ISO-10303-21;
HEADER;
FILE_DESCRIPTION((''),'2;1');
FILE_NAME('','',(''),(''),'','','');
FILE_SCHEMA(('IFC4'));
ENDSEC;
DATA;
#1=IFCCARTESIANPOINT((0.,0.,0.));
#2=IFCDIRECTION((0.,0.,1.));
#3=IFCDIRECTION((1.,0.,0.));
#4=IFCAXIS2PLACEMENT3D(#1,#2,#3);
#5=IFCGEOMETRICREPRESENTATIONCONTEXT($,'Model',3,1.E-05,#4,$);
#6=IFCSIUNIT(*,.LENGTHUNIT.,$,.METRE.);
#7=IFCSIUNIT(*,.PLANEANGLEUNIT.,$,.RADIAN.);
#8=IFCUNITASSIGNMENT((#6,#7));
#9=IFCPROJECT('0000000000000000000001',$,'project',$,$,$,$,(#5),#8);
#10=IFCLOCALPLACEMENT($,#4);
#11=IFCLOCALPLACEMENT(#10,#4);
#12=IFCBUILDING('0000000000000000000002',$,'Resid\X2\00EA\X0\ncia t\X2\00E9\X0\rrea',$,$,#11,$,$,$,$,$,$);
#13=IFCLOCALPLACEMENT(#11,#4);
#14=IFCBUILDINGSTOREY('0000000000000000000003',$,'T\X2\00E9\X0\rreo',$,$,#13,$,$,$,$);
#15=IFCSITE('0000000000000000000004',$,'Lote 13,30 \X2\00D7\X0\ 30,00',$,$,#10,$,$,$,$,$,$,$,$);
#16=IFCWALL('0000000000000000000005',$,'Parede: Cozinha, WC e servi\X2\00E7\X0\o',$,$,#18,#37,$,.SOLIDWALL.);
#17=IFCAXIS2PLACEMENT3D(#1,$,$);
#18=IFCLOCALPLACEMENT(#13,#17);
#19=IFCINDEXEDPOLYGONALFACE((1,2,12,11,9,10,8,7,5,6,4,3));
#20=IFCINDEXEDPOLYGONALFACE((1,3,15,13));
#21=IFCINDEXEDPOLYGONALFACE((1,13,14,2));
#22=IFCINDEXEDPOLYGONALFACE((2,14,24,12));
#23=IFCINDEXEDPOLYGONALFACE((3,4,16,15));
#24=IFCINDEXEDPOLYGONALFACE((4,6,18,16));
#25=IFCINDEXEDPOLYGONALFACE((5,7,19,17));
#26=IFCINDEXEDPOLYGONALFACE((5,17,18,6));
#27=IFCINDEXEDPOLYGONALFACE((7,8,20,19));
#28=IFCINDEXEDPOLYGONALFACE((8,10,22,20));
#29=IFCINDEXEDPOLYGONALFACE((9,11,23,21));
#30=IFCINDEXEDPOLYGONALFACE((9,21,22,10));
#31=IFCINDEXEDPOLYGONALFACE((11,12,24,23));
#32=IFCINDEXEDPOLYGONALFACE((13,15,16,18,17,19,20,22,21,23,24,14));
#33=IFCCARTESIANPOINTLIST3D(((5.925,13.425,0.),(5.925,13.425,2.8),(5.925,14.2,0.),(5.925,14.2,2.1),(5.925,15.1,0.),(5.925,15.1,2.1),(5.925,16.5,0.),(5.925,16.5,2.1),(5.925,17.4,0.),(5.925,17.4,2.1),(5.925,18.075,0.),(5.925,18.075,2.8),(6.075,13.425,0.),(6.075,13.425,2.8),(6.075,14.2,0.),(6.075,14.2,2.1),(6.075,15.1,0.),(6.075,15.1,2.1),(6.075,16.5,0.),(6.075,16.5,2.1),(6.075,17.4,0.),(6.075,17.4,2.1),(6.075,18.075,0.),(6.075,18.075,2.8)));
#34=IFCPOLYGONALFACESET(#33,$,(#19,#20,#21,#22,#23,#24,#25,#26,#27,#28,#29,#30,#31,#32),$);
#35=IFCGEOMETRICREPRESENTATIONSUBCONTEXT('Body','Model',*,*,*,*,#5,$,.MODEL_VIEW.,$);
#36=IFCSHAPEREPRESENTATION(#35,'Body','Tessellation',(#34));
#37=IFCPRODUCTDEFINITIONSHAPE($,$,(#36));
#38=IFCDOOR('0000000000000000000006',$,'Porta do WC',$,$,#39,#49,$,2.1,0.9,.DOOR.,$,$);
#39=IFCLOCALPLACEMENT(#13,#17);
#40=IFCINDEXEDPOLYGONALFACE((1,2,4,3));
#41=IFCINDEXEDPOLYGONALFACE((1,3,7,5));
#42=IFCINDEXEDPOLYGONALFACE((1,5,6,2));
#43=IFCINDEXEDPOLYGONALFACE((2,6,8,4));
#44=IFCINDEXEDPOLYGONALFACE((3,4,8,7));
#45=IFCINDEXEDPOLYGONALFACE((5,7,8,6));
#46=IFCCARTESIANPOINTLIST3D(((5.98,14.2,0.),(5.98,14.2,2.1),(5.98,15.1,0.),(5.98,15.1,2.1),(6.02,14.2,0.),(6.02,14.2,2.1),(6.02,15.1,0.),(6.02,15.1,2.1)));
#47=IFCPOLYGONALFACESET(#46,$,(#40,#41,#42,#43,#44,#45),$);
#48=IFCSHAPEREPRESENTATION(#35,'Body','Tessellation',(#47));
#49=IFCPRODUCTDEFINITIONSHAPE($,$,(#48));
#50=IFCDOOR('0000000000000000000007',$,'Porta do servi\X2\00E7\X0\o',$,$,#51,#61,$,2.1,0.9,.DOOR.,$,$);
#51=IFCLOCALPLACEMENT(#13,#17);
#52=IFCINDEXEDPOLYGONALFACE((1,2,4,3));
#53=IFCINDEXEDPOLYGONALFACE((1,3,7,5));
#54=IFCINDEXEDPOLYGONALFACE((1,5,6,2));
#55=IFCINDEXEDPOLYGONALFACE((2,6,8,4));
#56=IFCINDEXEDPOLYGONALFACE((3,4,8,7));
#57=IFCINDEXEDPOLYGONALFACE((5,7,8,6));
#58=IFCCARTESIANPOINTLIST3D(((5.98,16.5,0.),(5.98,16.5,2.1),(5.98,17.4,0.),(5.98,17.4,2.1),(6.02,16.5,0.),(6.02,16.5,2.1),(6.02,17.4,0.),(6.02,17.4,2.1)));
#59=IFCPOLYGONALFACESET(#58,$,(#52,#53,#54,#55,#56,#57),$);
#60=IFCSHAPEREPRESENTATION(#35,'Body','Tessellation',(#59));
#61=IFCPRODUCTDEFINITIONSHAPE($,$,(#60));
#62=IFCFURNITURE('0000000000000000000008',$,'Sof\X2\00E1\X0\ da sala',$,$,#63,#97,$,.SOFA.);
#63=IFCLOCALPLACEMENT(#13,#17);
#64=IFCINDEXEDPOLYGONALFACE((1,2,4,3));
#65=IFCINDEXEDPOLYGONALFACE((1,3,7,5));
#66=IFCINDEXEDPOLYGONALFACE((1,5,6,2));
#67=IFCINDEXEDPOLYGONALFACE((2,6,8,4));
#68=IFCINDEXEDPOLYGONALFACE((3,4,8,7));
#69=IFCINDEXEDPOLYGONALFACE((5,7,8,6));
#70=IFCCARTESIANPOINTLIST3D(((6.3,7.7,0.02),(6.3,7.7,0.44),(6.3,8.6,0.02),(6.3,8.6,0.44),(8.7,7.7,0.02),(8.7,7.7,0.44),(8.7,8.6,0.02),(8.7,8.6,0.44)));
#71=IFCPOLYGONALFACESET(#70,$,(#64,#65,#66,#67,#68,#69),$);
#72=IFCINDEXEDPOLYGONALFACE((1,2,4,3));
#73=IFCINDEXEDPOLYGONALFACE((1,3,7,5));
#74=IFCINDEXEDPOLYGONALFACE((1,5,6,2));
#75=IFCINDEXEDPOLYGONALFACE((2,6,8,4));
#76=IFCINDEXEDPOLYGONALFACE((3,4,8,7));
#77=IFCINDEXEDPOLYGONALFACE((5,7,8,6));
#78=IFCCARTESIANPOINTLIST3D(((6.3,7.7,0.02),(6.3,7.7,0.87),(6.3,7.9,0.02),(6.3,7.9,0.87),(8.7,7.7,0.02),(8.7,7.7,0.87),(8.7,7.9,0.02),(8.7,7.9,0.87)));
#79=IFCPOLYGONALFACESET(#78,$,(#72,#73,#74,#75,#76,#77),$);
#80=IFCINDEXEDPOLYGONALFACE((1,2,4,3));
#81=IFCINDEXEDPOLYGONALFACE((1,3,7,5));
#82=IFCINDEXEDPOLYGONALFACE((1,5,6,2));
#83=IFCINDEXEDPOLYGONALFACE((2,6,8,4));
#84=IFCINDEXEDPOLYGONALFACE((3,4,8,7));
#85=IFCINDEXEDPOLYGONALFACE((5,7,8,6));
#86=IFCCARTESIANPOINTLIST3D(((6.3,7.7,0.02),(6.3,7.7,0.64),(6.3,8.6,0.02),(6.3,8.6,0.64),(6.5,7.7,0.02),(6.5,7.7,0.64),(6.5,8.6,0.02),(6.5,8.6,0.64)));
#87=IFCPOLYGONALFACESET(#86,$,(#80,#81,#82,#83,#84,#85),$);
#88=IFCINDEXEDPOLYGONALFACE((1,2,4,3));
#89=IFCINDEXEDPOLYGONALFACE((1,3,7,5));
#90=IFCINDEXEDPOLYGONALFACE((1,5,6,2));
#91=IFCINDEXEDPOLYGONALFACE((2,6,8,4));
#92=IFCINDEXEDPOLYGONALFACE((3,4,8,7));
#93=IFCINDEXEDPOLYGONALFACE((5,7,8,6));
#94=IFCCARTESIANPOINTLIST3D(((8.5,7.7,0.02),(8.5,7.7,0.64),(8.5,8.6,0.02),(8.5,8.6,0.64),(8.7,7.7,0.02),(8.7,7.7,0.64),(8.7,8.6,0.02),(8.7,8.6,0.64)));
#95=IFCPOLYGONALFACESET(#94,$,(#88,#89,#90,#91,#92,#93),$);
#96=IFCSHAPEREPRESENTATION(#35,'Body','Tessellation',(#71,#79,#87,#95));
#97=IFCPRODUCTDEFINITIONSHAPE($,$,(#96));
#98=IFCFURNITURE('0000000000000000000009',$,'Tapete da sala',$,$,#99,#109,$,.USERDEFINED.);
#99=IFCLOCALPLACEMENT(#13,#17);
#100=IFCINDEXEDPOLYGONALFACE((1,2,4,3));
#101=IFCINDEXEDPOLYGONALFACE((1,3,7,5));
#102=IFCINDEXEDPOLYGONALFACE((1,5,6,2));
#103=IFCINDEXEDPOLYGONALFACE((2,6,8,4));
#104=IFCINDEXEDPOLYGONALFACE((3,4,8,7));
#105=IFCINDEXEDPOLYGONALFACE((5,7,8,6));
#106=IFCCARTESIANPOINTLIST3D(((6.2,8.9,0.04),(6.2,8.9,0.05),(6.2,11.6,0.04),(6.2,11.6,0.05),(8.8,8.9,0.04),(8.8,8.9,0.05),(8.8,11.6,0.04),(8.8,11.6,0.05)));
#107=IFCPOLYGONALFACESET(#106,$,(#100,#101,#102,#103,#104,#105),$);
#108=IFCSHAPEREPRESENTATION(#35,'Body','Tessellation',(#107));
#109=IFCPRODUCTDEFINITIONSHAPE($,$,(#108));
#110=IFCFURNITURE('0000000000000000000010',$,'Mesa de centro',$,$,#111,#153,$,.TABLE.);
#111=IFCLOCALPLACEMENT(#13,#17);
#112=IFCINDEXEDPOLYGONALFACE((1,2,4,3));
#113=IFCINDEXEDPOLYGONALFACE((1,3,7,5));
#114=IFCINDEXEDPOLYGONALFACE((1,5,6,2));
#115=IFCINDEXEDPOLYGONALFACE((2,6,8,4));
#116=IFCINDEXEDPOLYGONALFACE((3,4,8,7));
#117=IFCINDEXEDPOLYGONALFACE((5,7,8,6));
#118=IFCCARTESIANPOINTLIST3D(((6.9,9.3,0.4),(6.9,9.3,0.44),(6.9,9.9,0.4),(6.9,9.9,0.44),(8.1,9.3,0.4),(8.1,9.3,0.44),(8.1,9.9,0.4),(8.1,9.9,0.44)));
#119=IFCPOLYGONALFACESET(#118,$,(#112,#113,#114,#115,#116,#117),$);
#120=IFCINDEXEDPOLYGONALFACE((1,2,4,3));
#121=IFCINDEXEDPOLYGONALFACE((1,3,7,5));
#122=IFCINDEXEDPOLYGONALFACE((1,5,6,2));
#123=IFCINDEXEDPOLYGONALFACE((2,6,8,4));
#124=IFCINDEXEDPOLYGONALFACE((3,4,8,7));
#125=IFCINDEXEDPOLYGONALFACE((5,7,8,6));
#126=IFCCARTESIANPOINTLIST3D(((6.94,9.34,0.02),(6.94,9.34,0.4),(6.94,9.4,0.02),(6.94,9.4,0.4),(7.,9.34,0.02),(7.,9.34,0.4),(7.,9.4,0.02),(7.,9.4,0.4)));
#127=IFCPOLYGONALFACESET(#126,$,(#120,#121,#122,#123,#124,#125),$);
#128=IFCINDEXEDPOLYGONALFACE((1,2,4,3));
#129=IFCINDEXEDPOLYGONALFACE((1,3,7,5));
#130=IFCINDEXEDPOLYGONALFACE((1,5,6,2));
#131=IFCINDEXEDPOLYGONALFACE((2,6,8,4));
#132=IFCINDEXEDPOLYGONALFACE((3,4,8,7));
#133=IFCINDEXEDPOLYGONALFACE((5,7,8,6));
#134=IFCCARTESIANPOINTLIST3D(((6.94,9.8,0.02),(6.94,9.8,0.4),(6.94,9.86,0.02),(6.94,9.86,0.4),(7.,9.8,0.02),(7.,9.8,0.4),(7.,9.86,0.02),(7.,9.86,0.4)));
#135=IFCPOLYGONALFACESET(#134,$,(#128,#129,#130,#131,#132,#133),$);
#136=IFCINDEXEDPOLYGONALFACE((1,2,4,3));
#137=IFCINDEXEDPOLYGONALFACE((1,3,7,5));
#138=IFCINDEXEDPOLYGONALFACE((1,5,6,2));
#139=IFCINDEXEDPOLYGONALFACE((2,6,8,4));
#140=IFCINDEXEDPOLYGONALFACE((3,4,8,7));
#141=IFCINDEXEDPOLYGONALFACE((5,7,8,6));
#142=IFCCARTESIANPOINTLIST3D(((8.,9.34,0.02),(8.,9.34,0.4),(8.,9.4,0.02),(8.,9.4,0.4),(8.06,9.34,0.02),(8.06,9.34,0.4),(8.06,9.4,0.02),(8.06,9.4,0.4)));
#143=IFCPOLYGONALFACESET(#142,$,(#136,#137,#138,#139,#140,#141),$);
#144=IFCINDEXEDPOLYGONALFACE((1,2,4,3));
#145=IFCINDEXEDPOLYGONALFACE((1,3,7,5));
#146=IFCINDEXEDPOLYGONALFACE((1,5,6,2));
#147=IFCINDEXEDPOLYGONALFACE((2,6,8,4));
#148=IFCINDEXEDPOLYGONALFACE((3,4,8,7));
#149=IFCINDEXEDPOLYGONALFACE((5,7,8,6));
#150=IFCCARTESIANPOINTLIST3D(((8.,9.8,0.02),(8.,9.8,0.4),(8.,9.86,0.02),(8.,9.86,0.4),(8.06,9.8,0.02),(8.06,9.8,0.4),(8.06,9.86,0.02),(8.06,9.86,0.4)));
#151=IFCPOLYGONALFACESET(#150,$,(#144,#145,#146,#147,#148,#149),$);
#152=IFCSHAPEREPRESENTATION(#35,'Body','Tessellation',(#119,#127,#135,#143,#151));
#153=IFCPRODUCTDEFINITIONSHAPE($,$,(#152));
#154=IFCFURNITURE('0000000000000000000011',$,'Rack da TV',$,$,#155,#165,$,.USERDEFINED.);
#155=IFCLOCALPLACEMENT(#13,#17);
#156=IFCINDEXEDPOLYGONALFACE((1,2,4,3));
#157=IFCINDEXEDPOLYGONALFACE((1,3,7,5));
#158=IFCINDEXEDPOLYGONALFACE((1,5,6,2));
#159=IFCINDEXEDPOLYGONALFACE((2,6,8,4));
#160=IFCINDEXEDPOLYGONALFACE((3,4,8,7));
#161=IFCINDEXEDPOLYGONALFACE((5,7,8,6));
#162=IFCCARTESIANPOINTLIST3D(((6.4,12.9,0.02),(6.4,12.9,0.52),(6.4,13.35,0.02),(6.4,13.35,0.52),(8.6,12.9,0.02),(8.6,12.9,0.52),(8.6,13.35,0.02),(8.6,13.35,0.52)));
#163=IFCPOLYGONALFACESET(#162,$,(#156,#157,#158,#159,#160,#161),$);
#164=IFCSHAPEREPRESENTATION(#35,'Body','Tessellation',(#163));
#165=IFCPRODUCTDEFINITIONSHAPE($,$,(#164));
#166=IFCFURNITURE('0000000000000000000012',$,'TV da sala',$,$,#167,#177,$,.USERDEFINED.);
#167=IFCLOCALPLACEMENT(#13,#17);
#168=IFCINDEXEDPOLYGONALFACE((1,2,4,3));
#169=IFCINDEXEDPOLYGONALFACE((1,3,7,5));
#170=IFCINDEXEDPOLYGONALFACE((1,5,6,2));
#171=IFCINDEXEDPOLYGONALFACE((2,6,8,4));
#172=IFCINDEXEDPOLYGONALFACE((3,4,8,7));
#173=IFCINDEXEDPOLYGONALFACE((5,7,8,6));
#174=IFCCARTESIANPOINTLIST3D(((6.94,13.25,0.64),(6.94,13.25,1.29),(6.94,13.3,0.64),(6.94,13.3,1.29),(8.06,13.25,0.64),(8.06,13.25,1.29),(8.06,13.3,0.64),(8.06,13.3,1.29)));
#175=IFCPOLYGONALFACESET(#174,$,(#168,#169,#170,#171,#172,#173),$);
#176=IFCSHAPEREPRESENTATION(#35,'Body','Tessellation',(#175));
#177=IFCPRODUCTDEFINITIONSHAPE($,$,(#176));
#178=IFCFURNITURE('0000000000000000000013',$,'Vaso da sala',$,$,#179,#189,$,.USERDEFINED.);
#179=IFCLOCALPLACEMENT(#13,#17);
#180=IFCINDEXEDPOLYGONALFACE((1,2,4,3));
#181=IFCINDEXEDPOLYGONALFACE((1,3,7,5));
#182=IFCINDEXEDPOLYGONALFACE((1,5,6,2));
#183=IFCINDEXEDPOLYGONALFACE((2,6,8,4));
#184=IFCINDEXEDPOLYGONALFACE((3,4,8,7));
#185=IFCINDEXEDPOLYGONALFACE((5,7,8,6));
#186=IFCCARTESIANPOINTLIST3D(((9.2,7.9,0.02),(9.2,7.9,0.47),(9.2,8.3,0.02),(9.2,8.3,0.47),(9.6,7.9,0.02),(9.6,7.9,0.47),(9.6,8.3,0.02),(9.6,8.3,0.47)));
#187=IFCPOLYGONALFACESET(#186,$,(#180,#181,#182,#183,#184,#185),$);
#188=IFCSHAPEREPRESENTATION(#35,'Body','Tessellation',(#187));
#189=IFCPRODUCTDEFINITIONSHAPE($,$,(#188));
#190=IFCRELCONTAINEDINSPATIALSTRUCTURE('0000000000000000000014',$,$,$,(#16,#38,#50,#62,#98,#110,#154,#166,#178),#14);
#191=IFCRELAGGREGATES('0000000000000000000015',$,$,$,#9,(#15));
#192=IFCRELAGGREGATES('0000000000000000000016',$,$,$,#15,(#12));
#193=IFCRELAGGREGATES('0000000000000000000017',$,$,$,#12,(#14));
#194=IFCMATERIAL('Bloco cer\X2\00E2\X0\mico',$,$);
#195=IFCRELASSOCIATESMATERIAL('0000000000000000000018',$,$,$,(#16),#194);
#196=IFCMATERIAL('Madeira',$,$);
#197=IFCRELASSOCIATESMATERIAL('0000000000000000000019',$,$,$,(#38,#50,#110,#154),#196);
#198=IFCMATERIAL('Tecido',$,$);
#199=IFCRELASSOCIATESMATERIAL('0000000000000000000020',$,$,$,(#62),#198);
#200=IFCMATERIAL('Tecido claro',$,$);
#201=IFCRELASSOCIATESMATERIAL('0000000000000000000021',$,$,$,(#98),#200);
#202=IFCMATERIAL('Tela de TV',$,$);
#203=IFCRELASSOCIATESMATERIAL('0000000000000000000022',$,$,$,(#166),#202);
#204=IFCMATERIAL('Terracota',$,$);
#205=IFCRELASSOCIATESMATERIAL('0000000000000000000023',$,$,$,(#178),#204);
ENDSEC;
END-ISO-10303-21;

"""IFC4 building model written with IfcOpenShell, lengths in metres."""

from ifc_helpers import new_model, si_unit, frame, origin_with_axes, place, context, subcontext, project, spatial, line, indexed_curve, outline, extrude, material, element, fill, save


model = new_model("IFC4")

# Units and contexts
model_context = context("Model", 3, precision=1e-05, world=origin_with_axes())
body_context = subcontext(model_context, "Body", "Model", "MODEL_VIEW")
ifc_project = project(units=[si_unit("LENGTHUNIT", "METRE"), si_unit("PLANEANGLEUNIT", "RADIAN")], contexts=[model_context])

# Site, building, storey
site_placement = place(None, origin_with_axes())
site = spatial("IfcSite", under=ifc_project, at=site_placement, Name="Lote 13,30 × 30,00")
building_placement = place(site_placement, origin_with_axes())
building = spatial("IfcBuilding", under=site, at=building_placement, Name="Residência térrea")
storey_placement = place(building_placement, origin_with_axes())
storey = spatial("IfcBuildingStorey", under=building, at=storey_placement, Name="Térreo")

# Shared definitions
ifc_material_1 = material(Name="Concreto armado")

# Shared definitions
ifc_material_2 = material(Name="Bloco cerâmico")

# Wall, openings, doors
wall_1_placement = place(storey_placement, frame((5.925, 13.425, 0.0), z_axis=(0.0, 0.0, 1.0), x_axis=(1.0, 0.0, 0.0)))
wall_1 = element("IfcWall", 1, at=wall_1_placement, inside=storey, material=ifc_material_2, Name="Parede: Cozinha, WC e serviço", PredefinedType="SOLIDWALL", context=body_context, shape_type="SweptSolid", body=[
    extrude(outline(indexed_curve([(0.0, 0.0), (0.15, 0.0), (0.15, 4.65), (0.0, 4.65)], segments=[line(1, 2, 3, 4, 1)])), origin_with_axes(), (0.0, 0.0, 1.0), 2.8),
])
opening_1_placement = place(wall_1_placement, frame((-0.05, 0.775, 0.0), z_axis=(0.0, 0.0, 1.0), x_axis=(1.0, 0.0, 0.0)))
opening_1 = element("IfcOpeningElement", 2, at=opening_1_placement, cuts=wall_1, material=ifc_material_1, PredefinedType="OPENING", context=body_context, shape_type="SweptSolid", body=[
    extrude(outline(indexed_curve([(0.0, 0.0), (0.25, 0.0), (0.25, 0.9), (0.0, 0.9)], segments=[line(1, 2, 3, 4, 1)])), origin_with_axes(), (0.0, 0.0, 1.0), 2.1),
])
opening_2_placement = place(wall_1_placement, frame((-0.05, 3.075, 0.0), z_axis=(0.0, 0.0, 1.0), x_axis=(1.0, 0.0, 0.0)))
opening_2 = element("IfcOpeningElement", 3, at=opening_2_placement, cuts=wall_1, material=ifc_material_1, PredefinedType="OPENING", context=body_context, shape_type="SweptSolid", body=[
    extrude(outline(indexed_curve([(0.0, 0.0), (0.25, 0.0), (0.25, 0.9), (0.0, 0.9)], segments=[line(1, 2, 3, 4, 1)])), origin_with_axes(), (0.0, 0.0, 1.0), 2.1),
])
ifc_material_3 = material(Name="Madeira")
door_1_placement = place(storey_placement, frame((5.98, 14.2, 0.0), z_axis=(0.0, 0.0, 1.0), x_axis=(1.0, 0.0, 0.0)))
door_1 = element("IfcDoor", 4, at=door_1_placement, inside=storey, material=ifc_material_3, Name="Porta do WC", OverallHeight=2.1, OverallWidth=0.9, PredefinedType="DOOR", context=body_context, shape_type="SweptSolid", body=[
    extrude(outline(indexed_curve([(0.0, 0.0), (0.04, 0.0), (0.04, 0.9), (0.0, 0.9)], segments=[line(1, 2, 3, 4, 1)])), origin_with_axes(), (0.0, 0.0, 1.0), 2.1),
])
fill(opening_1, door_1)
door_2_placement = place(storey_placement, frame((5.98, 16.5, 0.0), z_axis=(0.0, 0.0, 1.0), x_axis=(1.0, 0.0, 0.0)))
door_2 = element("IfcDoor", 5, at=door_2_placement, inside=storey, material=ifc_material_3, Name="Porta do serviço", OverallHeight=2.1, OverallWidth=0.9, PredefinedType="DOOR", context=body_context, shape_type="SweptSolid", body=[
    extrude(outline(indexed_curve([(0.0, 0.0), (0.04, 0.0), (0.04, 0.9), (0.0, 0.9)], segments=[line(1, 2, 3, 4, 1)])), origin_with_axes(), (0.0, 0.0, 1.0), 2.1),
])
fill(opening_2, door_2)

# Furniture
ifc_material_4 = material(Name="Tecido")
furniture_1_placement = place(storey_placement, frame((6.3, 7.7, 0.02), z_axis=(0.0, 0.0, 1.0), x_axis=(1.0, 0.0, 0.0)))
element("IfcFurniture", 6, at=furniture_1_placement, inside=storey, material=ifc_material_4, Name="Sofá da sala", PredefinedType="SOFA", context=body_context, shape_type="SweptSolid", body=[
    extrude(outline(indexed_curve([(0.0, 0.0), (2.4, 0.0), (2.4, 0.9), (0.0, 0.9)], segments=[line(1, 2, 3, 4, 1)])), origin_with_axes(), (0.0, 0.0, 1.0), 0.42),
    extrude(outline(indexed_curve([(0.0, 0.0), (2.4, 0.0), (2.4, 0.2), (0.0, 0.2)], segments=[line(1, 2, 3, 4, 1)])), origin_with_axes(), (0.0, 0.0, 1.0), 0.85),
    extrude(outline(indexed_curve([(0.0, 0.0), (0.2, 0.0), (0.2, 0.9), (0.0, 0.9)], segments=[line(1, 2, 3, 4, 1)])), origin_with_axes(), (0.0, 0.0, 1.0), 0.62),
    extrude(outline(indexed_curve([(2.2, 0.0), (2.4, 0.0), (2.4, 0.9), (2.2, 0.9)], segments=[line(1, 2, 3, 4, 1)])), origin_with_axes(), (0.0, 0.0, 1.0), 0.62),
])
ifc_material_5 = material(Name="Tecido claro")
furniture_2_placement = place(storey_placement, frame((6.2, 8.9, 0.04), z_axis=(0.0, 0.0, 1.0), x_axis=(1.0, 0.0, 0.0)))
element("IfcFurniture", 7, at=furniture_2_placement, inside=storey, material=ifc_material_5, Name="Tapete da sala", PredefinedType="USERDEFINED", context=body_context, shape_type="SweptSolid", body=[
    extrude(outline(indexed_curve([(0.0, 0.0), (2.6, 0.0), (2.6, 2.7), (0.0, 2.7)], segments=[line(1, 2, 3, 4, 1)])), origin_with_axes(), (0.0, 0.0, 1.0), 0.01),
])
furniture_3_placement = place(storey_placement, frame((6.9, 9.3, 0.02), z_axis=(0.0, 0.0, 1.0), x_axis=(1.0, 0.0, 0.0)))
element("IfcFurniture", 8, at=furniture_3_placement, inside=storey, material=ifc_material_3, Name="Mesa de centro", PredefinedType="TABLE", context=body_context, shape_type="SweptSolid", body=[
    extrude(outline(indexed_curve([(0.0, 0.0), (1.2, 0.0), (1.2, 0.6), (0.0, 0.6)], segments=[line(1, 2, 3, 4, 1)])), frame((0.0, 0.0, 0.38), z_axis=(0.0, 0.0, 1.0), x_axis=(1.0, 0.0, 0.0)), (0.0, 0.0, 1.0), 0.04),
    extrude(outline(indexed_curve([(0.04, 0.04), (0.1, 0.04), (0.1, 0.1), (0.04, 0.1)], segments=[line(1, 2, 3, 4, 1)])), origin_with_axes(), (0.0, 0.0, 1.0), 0.38),
    extrude(outline(indexed_curve([(0.04, 0.5), (0.1, 0.5), (0.1, 0.56), (0.04, 0.56)], segments=[line(1, 2, 3, 4, 1)])), origin_with_axes(), (0.0, 0.0, 1.0), 0.38),
    extrude(outline(indexed_curve([(1.1, 0.04), (1.16, 0.04), (1.16, 0.1), (1.1, 0.1)], segments=[line(1, 2, 3, 4, 1)])), origin_with_axes(), (0.0, 0.0, 1.0), 0.38),
    extrude(outline(indexed_curve([(1.1, 0.5), (1.16, 0.5), (1.16, 0.56), (1.1, 0.56)], segments=[line(1, 2, 3, 4, 1)])), origin_with_axes(), (0.0, 0.0, 1.0), 0.38),
])
furniture_4_placement = place(storey_placement, frame((6.4, 12.9, 0.02), z_axis=(0.0, 0.0, 1.0), x_axis=(1.0, 0.0, 0.0)))
element("IfcFurniture", 9, at=furniture_4_placement, inside=storey, material=ifc_material_3, Name="Rack da TV", PredefinedType="USERDEFINED", context=body_context, shape_type="SweptSolid", body=[
    extrude(outline(indexed_curve([(0.0, 0.0), (2.2, 0.0), (2.2, 0.45), (0.0, 0.45)], segments=[line(1, 2, 3, 4, 1)])), origin_with_axes(), (0.0, 0.0, 1.0), 0.5),
])
ifc_material_6 = material(Name="Tela de TV")
furniture_5_placement = place(storey_placement, frame((6.94, 13.25, 0.64), z_axis=(0.0, 0.0, 1.0), x_axis=(1.0, 0.0, 0.0)))
element("IfcFurniture", 10, at=furniture_5_placement, inside=storey, material=ifc_material_6, Name="TV da sala", PredefinedType="USERDEFINED", context=body_context, shape_type="SweptSolid", body=[
    extrude(outline(indexed_curve([(0.0, 0.0), (1.12, 0.0), (1.12, 0.05), (0.0, 0.05)], segments=[line(1, 2, 3, 4, 1)])), origin_with_axes(), (0.0, 0.0, 1.0), 0.65),
])
ifc_material_7 = material(Name="Terracota")
furniture_6_placement = place(storey_placement, frame((9.2, 7.9, 0.02), z_axis=(0.0, 0.0, 1.0), x_axis=(1.0, 0.0, 0.0)))
element("IfcFurniture", 11, at=furniture_6_placement, inside=storey, material=ifc_material_7, Name="Vaso da sala", PredefinedType="USERDEFINED", context=body_context, shape_type="SweptSolid", body=[
    extrude(outline(indexed_curve([(0.0, 0.0), (0.4, 0.0), (0.4, 0.4), (0.0, 0.4)], segments=[line(1, 2, 3, 4, 1)])), origin_with_axes(), (0.0, 0.0, 1.0), 0.45),
])

save(model, "model.ifc")
